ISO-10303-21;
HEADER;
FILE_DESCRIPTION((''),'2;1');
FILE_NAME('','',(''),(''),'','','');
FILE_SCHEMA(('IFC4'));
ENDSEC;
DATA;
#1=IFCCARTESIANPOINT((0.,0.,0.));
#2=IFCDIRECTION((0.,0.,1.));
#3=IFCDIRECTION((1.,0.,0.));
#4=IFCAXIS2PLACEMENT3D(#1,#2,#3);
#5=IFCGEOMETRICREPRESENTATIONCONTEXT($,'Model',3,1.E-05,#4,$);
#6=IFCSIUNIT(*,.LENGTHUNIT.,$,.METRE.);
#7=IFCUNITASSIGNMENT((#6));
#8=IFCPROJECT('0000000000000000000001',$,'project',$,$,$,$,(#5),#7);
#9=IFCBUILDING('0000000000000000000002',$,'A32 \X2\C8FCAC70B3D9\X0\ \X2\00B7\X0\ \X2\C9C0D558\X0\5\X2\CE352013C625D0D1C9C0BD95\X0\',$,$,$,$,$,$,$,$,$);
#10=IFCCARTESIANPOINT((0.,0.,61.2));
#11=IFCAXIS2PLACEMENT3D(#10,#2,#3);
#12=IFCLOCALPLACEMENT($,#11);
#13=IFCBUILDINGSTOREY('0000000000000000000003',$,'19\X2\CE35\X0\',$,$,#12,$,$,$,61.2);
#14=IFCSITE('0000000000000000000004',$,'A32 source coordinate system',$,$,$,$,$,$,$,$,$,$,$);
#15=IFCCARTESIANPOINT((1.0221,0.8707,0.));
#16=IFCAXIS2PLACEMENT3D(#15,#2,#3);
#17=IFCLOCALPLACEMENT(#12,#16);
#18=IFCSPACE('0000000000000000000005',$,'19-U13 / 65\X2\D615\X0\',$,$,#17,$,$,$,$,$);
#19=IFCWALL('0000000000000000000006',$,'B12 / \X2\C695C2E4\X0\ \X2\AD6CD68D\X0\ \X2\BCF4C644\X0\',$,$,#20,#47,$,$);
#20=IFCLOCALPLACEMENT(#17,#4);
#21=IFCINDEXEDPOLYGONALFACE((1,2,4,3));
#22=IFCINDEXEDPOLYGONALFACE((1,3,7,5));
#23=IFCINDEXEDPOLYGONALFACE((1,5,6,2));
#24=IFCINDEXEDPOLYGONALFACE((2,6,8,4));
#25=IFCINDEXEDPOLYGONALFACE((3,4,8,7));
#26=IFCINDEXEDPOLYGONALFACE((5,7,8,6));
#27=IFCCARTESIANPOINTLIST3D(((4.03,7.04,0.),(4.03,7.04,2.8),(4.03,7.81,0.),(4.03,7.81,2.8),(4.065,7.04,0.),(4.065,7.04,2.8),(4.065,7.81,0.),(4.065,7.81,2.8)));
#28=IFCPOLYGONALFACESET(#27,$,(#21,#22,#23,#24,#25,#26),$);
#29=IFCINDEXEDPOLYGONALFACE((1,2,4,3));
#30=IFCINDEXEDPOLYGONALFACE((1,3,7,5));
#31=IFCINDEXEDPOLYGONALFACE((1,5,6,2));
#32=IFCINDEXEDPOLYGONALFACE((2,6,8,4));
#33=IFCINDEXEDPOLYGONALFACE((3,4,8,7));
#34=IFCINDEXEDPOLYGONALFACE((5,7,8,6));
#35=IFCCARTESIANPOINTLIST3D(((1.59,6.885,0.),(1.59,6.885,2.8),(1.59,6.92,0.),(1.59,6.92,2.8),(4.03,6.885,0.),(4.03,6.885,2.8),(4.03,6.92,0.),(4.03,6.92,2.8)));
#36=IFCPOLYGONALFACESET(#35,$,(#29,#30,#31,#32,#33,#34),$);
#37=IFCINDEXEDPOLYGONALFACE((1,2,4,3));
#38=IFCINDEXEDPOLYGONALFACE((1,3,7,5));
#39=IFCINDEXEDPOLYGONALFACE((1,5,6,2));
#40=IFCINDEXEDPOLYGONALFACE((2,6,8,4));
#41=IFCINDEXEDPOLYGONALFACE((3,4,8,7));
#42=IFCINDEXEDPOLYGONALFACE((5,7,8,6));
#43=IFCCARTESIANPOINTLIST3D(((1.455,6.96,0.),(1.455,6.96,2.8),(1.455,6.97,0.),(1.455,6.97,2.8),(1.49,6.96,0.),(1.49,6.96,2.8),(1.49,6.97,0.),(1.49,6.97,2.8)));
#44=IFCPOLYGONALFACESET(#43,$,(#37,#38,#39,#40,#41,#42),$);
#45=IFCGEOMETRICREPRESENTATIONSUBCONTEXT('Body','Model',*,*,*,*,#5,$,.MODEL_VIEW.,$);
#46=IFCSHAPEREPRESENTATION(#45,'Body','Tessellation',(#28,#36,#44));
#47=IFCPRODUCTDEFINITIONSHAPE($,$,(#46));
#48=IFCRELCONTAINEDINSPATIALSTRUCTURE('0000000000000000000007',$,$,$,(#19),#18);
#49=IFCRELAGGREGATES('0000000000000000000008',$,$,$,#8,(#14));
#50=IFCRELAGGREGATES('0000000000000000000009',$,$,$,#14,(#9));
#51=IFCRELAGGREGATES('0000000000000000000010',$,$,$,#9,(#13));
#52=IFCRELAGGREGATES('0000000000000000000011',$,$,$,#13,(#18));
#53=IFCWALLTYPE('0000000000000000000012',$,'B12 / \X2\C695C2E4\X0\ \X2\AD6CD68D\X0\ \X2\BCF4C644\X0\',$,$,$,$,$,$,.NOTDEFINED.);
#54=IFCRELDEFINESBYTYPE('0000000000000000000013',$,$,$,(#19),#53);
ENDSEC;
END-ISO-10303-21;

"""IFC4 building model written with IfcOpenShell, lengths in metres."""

from ifc_helpers import new_model, si_unit, frame, origin, origin_with_axes, place, context, subcontext, project, spatial, polyline, outline, extrude, source, transform, mapped, type_object, type_shapes, element, save


model = new_model("IFC4")

# Units and contexts
model_context = context("Model", 3, precision=1e-05, world=origin_with_axes())
body_context = subcontext(model_context, "Body", "Model", "MODEL_VIEW")
ifc_project = project(units=[si_unit("LENGTHUNIT", "METRE")], contexts=[model_context])

# Site, building, storey, space
storey_placement = place(None, frame((0.0, 0.0, 61.2), z_axis=(0.0, 0.0, 1.0), x_axis=(1.0, 0.0, 0.0)))
space_placement = place(storey_placement, frame((1.0221, 0.8707, 0.0), z_axis=(0.0, 0.0, 1.0), x_axis=(1.0, 0.0, 0.0)))
site = spatial("IfcSite", under=ifc_project, Name="A32 source coordinate system")
building = spatial("IfcBuilding", under=site, Name="A32 주거동 · 지하5층–옥탑지붕")
storey = spatial("IfcBuildingStorey", under=building, at=storey_placement, Name="19층", Elevation=61.2)
space = spatial("IfcSpace", under=storey, at=space_placement, Name="19-U13 / 65형")

# Wall
wall_type_1 = type_object("IfcWallType", Name="B12 / 욕실 구획 보완", PredefinedType="NOTDEFINED")
shared_shape_1 = source(origin(), body_context, "Body", "SweptSolid", [
    extrude(outline(polyline([(4.065, 7.04), (4.03, 7.04), (4.03, 7.81), (4.065, 7.81), (4.065, 7.04)])), origin(), (0.0, 0.0, 1.0), 2.8),
    extrude(outline(polyline([(1.59, 6.92), (4.03, 6.92), (4.03, 6.885), (1.59, 6.885), (1.59, 6.92)])), origin(), (0.0, 0.0, 1.0), 2.8),
    extrude(outline(polyline([(1.455, 6.97), (1.49, 6.97), (1.49, 6.96), (1.455, 6.96), (1.455, 6.97)])), origin(), (0.0, 0.0, 1.0), 2.8),
])
type_shapes(wall_type_1, [shared_shape_1])
wall_1_placement = place(space_placement, origin_with_axes())
element("IfcWall", 1, at=wall_1_placement, inside=space, type_object=wall_type_1, Name="B12 / 욕실 구획 보완", context=body_context, shape_type="MappedRepresentation", body=[
    mapped(shared_shape_1, transform((0.0, 0.0, 0.0), scale=1.0)),
])

save(model, "model.ifc")
